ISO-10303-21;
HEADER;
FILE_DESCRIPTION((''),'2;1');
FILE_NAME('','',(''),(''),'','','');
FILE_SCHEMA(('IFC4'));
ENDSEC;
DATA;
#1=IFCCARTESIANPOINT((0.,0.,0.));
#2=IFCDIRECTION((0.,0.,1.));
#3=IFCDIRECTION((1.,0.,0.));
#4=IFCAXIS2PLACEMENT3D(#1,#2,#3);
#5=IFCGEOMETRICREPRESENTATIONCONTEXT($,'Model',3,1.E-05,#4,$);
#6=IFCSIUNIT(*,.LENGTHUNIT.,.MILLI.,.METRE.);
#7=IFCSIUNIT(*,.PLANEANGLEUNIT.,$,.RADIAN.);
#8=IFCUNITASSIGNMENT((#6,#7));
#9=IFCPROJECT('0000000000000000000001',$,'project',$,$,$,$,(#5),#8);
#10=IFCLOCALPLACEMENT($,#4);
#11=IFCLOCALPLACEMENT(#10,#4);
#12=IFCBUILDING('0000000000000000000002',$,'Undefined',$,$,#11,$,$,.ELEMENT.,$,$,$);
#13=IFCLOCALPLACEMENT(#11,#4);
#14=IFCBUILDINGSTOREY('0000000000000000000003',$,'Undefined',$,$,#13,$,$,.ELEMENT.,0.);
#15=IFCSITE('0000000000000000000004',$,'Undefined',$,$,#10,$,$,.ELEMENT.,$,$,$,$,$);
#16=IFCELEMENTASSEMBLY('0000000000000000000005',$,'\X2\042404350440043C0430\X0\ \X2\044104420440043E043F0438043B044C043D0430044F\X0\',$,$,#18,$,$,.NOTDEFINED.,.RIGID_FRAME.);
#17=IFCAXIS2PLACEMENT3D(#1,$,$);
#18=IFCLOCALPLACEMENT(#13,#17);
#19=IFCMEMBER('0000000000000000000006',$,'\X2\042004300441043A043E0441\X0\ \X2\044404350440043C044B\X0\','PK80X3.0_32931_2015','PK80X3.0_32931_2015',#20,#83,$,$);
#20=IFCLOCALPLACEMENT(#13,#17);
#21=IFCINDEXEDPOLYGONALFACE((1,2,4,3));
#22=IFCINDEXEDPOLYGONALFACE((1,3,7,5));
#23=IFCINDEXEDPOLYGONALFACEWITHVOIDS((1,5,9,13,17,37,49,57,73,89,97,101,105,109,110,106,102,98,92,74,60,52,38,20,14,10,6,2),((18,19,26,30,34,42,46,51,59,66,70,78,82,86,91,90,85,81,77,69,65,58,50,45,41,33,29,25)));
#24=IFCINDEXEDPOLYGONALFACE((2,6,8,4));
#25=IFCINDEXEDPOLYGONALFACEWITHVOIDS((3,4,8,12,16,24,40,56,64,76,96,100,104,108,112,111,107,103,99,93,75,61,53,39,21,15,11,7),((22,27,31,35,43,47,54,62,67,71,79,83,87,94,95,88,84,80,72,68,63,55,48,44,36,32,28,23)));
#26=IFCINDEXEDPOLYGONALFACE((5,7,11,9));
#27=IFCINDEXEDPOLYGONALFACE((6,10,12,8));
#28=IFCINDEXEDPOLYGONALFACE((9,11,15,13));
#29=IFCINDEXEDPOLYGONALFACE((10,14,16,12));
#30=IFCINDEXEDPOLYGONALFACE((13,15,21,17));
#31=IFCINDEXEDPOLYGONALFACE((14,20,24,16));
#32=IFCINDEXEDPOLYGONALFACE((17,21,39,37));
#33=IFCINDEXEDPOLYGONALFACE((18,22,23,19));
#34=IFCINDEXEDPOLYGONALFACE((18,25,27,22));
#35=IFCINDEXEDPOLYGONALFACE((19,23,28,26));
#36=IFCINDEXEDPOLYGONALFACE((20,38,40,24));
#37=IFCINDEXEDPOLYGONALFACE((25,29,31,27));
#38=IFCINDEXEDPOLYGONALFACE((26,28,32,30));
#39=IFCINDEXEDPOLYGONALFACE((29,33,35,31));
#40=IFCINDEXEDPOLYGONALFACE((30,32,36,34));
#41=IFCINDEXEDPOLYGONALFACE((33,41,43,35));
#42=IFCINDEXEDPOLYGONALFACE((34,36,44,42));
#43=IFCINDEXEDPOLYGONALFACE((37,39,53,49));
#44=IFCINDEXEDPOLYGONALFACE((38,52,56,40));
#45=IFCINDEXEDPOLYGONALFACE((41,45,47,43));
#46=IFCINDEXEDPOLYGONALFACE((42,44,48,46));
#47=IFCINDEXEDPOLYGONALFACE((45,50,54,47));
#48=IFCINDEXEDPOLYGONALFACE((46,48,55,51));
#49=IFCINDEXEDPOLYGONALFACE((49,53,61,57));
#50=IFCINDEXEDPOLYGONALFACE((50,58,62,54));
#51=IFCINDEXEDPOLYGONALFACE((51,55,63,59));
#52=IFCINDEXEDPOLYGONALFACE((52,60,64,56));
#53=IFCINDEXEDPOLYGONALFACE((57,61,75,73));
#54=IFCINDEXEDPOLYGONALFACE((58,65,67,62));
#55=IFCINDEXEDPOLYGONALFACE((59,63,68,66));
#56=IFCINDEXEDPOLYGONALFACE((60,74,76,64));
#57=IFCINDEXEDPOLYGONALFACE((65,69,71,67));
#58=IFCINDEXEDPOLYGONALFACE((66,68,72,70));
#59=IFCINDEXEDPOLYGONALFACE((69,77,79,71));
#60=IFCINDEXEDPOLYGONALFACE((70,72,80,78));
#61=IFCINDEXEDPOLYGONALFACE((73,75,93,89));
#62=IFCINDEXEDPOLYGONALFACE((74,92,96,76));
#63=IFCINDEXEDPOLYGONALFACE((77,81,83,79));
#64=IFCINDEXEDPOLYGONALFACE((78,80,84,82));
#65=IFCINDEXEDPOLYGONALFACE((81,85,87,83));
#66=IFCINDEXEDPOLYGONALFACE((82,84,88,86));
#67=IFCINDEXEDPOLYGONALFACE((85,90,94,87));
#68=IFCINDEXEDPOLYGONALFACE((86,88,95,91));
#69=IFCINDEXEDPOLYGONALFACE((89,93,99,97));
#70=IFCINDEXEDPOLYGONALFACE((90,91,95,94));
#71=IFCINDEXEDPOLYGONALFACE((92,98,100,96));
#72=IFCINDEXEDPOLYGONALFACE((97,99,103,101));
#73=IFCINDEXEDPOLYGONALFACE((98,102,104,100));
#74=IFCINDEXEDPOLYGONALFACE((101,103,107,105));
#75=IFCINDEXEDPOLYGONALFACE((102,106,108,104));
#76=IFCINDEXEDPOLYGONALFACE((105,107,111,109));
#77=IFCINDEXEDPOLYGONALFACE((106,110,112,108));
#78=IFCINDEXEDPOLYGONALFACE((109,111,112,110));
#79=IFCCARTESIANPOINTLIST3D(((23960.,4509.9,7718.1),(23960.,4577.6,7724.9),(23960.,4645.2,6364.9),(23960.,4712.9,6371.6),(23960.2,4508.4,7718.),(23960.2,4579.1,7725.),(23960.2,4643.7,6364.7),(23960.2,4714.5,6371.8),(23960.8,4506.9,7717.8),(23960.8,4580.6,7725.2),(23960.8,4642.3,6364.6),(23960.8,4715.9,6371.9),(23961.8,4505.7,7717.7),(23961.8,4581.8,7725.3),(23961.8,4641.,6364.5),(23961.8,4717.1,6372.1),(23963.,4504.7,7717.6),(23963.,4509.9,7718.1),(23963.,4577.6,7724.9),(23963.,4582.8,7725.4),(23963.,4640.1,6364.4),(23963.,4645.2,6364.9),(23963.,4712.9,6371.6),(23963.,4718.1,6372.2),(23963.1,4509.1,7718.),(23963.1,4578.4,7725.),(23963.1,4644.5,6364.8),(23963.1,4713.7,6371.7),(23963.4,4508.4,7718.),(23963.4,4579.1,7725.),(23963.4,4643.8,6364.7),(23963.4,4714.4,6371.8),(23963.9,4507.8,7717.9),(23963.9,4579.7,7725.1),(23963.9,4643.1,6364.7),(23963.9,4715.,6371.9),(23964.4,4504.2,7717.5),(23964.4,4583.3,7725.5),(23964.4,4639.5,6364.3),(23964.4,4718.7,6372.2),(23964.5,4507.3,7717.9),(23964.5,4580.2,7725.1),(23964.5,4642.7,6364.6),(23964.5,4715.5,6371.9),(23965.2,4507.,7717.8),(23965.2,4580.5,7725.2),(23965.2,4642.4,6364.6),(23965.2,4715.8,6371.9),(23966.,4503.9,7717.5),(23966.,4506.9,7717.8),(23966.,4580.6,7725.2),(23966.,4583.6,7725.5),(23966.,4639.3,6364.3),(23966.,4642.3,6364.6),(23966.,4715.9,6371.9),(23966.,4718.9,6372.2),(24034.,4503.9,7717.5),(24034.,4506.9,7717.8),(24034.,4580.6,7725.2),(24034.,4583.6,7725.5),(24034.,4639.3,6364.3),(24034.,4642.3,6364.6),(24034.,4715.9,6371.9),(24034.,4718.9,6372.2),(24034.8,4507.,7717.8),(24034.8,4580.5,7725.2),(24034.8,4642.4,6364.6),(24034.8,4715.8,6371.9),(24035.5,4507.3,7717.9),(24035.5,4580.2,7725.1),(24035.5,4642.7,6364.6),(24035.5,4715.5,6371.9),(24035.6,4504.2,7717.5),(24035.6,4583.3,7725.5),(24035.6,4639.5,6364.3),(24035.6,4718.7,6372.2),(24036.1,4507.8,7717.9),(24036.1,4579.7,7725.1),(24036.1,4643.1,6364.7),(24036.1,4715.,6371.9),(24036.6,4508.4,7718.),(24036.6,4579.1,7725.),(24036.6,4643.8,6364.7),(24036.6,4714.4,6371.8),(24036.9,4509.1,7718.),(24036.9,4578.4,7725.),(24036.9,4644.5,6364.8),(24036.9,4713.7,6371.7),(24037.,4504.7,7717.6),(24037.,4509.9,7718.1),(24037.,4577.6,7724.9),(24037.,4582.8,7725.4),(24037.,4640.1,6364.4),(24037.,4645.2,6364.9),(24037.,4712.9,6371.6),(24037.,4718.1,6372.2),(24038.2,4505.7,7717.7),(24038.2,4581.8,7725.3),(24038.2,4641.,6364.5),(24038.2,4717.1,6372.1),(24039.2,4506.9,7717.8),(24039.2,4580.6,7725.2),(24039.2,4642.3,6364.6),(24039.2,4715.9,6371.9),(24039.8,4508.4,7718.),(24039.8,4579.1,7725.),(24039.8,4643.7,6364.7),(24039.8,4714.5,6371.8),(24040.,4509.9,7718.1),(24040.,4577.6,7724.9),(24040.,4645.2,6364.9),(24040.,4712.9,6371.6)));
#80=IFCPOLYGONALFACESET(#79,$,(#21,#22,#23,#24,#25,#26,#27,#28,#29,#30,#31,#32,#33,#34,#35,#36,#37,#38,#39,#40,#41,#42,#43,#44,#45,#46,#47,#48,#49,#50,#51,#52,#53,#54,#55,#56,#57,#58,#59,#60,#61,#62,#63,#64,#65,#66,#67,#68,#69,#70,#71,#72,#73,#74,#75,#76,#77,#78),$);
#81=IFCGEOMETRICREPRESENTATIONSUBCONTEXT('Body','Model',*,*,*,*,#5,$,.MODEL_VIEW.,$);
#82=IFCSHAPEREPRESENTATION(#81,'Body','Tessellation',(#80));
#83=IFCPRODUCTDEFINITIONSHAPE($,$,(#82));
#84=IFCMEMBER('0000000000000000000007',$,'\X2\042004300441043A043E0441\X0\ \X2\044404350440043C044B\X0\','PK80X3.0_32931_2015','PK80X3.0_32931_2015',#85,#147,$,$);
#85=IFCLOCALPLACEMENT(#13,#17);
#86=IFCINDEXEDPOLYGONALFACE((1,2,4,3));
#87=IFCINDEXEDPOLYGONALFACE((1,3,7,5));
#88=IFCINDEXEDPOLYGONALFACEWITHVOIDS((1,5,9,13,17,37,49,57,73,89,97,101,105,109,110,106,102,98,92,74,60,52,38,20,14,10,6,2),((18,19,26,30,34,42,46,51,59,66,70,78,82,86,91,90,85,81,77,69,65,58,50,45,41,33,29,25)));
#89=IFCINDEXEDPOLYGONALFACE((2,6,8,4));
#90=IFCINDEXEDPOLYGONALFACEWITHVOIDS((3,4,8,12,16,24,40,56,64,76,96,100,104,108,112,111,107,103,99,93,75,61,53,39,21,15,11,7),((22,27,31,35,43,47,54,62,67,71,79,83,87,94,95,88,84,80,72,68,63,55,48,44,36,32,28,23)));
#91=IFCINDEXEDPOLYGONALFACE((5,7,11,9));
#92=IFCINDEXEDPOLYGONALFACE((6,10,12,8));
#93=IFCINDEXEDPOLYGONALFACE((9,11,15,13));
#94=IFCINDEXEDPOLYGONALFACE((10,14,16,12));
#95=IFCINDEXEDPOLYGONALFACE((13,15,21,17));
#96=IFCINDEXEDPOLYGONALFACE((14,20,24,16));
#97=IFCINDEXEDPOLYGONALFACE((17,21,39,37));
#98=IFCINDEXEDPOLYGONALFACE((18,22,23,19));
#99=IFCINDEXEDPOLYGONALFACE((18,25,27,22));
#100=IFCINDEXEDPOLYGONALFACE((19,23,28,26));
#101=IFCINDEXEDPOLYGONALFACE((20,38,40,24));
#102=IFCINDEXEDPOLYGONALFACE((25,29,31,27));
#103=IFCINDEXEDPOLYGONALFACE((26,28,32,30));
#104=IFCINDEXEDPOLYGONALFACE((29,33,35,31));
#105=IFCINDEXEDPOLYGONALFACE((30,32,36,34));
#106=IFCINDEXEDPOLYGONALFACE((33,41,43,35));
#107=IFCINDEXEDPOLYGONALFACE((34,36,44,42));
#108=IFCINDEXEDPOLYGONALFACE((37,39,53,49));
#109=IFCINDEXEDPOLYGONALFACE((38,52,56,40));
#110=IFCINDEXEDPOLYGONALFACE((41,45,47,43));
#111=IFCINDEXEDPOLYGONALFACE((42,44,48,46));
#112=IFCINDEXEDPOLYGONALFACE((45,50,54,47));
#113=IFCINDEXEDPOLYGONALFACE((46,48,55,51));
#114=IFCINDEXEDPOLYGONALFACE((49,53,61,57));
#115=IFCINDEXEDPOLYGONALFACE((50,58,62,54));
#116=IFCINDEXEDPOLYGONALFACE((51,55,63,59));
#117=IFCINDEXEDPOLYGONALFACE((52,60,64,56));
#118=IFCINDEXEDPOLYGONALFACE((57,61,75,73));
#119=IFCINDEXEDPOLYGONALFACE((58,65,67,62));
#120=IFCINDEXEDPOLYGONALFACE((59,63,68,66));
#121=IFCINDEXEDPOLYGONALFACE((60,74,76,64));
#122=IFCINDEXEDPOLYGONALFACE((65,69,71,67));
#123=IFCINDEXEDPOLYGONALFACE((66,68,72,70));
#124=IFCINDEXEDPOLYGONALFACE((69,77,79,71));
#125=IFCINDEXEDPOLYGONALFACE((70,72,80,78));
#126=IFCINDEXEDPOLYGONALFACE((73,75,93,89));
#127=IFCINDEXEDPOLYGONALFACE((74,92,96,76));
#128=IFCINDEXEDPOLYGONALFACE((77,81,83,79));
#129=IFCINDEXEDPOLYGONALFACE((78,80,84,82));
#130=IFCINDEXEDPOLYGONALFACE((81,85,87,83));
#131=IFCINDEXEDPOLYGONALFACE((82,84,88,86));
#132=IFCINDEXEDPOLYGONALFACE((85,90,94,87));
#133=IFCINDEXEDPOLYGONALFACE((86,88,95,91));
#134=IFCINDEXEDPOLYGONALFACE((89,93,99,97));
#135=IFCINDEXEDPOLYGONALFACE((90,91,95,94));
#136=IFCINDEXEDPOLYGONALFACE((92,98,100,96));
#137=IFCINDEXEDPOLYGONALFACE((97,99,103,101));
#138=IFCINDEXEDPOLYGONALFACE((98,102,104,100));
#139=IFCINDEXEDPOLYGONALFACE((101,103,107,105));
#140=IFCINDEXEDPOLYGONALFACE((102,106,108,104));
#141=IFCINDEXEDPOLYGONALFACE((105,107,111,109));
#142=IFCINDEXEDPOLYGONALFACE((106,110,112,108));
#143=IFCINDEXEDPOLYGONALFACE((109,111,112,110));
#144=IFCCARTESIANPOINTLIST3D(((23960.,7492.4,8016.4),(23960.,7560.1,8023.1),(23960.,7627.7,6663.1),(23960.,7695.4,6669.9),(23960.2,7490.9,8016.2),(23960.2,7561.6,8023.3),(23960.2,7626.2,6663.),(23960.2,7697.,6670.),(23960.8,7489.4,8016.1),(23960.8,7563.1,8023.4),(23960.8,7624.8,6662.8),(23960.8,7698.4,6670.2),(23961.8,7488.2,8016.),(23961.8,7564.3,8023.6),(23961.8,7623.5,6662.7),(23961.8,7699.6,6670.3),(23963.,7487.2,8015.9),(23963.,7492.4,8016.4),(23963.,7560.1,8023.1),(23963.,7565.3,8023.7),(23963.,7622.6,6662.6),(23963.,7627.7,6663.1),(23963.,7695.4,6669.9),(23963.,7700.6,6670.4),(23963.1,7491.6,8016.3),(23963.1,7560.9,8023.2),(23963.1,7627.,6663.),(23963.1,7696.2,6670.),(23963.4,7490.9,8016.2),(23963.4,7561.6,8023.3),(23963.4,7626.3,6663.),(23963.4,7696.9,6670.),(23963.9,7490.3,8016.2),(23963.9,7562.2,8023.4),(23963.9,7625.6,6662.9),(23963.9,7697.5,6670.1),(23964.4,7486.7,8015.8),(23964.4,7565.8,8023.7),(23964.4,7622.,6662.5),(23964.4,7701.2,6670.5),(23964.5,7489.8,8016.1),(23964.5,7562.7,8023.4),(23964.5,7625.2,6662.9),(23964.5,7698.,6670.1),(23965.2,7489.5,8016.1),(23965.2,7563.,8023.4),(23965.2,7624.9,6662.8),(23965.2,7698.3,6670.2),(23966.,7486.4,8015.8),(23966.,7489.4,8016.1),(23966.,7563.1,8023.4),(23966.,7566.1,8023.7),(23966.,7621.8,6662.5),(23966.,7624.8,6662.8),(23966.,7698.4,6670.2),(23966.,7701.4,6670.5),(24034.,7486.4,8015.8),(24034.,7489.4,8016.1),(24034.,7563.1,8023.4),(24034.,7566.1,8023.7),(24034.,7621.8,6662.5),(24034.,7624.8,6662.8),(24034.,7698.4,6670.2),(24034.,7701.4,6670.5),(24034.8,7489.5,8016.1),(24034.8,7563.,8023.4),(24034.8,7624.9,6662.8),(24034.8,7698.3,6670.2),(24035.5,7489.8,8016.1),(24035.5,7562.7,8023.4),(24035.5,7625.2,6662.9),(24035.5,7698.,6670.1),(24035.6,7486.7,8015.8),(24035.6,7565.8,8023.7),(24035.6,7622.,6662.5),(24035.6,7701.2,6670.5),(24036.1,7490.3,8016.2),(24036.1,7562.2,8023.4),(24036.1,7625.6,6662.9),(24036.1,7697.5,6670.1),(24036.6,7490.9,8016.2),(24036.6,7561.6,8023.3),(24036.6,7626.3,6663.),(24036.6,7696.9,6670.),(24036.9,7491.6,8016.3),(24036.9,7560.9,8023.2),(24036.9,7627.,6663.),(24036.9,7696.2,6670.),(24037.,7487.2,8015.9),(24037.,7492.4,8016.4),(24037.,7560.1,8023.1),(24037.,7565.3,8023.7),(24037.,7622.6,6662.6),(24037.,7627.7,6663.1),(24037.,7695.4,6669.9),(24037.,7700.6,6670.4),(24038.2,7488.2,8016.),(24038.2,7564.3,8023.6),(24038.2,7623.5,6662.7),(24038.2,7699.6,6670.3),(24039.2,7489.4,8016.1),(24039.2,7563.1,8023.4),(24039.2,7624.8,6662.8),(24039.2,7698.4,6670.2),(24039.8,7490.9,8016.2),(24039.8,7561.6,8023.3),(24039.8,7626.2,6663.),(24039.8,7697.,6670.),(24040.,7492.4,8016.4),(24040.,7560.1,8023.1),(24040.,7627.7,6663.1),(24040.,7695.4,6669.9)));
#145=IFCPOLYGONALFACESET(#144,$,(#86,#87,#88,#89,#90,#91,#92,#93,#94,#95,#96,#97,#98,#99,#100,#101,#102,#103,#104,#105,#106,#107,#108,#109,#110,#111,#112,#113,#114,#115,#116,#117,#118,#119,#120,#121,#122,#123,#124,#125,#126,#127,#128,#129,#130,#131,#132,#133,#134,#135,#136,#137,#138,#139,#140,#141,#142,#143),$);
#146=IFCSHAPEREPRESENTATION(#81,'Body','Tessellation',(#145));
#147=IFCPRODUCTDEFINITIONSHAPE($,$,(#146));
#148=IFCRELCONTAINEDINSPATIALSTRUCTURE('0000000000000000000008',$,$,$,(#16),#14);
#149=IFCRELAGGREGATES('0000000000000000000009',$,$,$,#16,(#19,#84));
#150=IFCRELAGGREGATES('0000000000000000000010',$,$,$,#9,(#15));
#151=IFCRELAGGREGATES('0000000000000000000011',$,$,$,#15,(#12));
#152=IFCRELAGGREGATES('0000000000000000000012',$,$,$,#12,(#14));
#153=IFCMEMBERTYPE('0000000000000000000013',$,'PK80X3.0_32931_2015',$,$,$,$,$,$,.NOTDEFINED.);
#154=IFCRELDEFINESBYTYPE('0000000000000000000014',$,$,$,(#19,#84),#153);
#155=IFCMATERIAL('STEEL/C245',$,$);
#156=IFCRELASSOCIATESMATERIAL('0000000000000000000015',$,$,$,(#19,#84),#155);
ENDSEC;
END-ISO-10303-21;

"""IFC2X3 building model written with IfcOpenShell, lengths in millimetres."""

from ifc_helpers import new_model, si_unit, frame, origin_with_axes, origin_2d_with_axis, place, context, subcontext, project, spatial, hollow_rectangle, extrude, material, type_object, element, aggregate, save


model = new_model("IFC2X3")

# Units and contexts
model_context = context("Model", 3, precision=1e-05, world=origin_with_axes())
body_context = subcontext(model_context, "Body", "Model", "MODEL_VIEW")
ifc_project = project(units=[si_unit("LENGTHUNIT", "METRE", prefix="MILLI"), si_unit("PLANEANGLEUNIT", "RADIAN")], contexts=[model_context])

# Site, building, storey
site_placement = place(None, origin_with_axes())
site = spatial("IfcSite", under=ifc_project, at=site_placement, Name="Undefined", CompositionType="ELEMENT")
building_placement = place(site_placement, origin_with_axes())
building = spatial("IfcBuilding", under=site, at=building_placement, Name="Undefined", CompositionType="ELEMENT")
storey_placement = place(building_placement, origin_with_axes())
storey = spatial("IfcBuildingStorey", under=building, at=storey_placement, Name="Undefined", CompositionType="ELEMENT", Elevation=0.0)

# Shared definitions
ifc_material_1 = material(Name="STEEL/C245")

# Element assembly, members
assembly_1_placement = place(storey_placement, origin_with_axes())
assembly_1 = element("IfcElementAssembly", 1, at=assembly_1_placement, inside=storey, Name="Ферма стропильная", AssemblyPlace="NOTDEFINED", PredefinedType="RIGID_FRAME")
member_type_1 = type_object("IfcMemberType", Name="PK80X3.0_32931_2015", PredefinedType="NOTDEFINED")
member_1_placement = place(assembly_1_placement, frame((24000.0, 4543.8, 7721.5), z_axis=(0.0, 0.995037, 0.099504), x_axis=(0.0, 0.099504, -0.995037)))
member_1 = element("IfcMember", 2, at=member_1_placement, type_object=member_type_1, material=ifc_material_1, Name="Раскос фермы", Description="PK80X3.0_32931_2015", ObjectType="PK80X3.0_32931_2015", context=body_context, shape_type="SweptSolid", body=[
    extrude(hollow_rectangle(XDim=80.0, YDim=80.0, WallThickness=3.0, InnerFilletRadius=3.0, OuterFilletRadius=6.0, at=origin_2d_with_axis()), frame((1360.0, 0.0, 0.0), z_axis=(-1.0, 0.0, 0.0), x_axis=(0.0, -1.0, 0.0)), (0.0, 0.0, 1.0), 1360.0),
])
member_2_placement = place(assembly_1_placement, frame((24000.0, 7526.3, 8019.8), z_axis=(0.0, 0.995037, 0.099504), x_axis=(0.0, 0.099504, -0.995037)))
member_2 = element("IfcMember", 3, at=member_2_placement, type_object=member_type_1, material=ifc_material_1, Name="Раскос фермы", Description="PK80X3.0_32931_2015", ObjectType="PK80X3.0_32931_2015", context=body_context, shape_type="SweptSolid", body=[
    extrude(hollow_rectangle(XDim=80.0, YDim=80.0, WallThickness=3.0, InnerFilletRadius=3.0, OuterFilletRadius=6.0, at=origin_2d_with_axis()), frame((1360.0, 0.0, 0.0), z_axis=(-1.0, 0.0, 0.0), x_axis=(0.0, -1.0, 0.0)), (0.0, 0.0, 1.0), 1360.0),
])
aggregate(assembly_1, [member_1, member_2])

save(model, "model.ifc")
